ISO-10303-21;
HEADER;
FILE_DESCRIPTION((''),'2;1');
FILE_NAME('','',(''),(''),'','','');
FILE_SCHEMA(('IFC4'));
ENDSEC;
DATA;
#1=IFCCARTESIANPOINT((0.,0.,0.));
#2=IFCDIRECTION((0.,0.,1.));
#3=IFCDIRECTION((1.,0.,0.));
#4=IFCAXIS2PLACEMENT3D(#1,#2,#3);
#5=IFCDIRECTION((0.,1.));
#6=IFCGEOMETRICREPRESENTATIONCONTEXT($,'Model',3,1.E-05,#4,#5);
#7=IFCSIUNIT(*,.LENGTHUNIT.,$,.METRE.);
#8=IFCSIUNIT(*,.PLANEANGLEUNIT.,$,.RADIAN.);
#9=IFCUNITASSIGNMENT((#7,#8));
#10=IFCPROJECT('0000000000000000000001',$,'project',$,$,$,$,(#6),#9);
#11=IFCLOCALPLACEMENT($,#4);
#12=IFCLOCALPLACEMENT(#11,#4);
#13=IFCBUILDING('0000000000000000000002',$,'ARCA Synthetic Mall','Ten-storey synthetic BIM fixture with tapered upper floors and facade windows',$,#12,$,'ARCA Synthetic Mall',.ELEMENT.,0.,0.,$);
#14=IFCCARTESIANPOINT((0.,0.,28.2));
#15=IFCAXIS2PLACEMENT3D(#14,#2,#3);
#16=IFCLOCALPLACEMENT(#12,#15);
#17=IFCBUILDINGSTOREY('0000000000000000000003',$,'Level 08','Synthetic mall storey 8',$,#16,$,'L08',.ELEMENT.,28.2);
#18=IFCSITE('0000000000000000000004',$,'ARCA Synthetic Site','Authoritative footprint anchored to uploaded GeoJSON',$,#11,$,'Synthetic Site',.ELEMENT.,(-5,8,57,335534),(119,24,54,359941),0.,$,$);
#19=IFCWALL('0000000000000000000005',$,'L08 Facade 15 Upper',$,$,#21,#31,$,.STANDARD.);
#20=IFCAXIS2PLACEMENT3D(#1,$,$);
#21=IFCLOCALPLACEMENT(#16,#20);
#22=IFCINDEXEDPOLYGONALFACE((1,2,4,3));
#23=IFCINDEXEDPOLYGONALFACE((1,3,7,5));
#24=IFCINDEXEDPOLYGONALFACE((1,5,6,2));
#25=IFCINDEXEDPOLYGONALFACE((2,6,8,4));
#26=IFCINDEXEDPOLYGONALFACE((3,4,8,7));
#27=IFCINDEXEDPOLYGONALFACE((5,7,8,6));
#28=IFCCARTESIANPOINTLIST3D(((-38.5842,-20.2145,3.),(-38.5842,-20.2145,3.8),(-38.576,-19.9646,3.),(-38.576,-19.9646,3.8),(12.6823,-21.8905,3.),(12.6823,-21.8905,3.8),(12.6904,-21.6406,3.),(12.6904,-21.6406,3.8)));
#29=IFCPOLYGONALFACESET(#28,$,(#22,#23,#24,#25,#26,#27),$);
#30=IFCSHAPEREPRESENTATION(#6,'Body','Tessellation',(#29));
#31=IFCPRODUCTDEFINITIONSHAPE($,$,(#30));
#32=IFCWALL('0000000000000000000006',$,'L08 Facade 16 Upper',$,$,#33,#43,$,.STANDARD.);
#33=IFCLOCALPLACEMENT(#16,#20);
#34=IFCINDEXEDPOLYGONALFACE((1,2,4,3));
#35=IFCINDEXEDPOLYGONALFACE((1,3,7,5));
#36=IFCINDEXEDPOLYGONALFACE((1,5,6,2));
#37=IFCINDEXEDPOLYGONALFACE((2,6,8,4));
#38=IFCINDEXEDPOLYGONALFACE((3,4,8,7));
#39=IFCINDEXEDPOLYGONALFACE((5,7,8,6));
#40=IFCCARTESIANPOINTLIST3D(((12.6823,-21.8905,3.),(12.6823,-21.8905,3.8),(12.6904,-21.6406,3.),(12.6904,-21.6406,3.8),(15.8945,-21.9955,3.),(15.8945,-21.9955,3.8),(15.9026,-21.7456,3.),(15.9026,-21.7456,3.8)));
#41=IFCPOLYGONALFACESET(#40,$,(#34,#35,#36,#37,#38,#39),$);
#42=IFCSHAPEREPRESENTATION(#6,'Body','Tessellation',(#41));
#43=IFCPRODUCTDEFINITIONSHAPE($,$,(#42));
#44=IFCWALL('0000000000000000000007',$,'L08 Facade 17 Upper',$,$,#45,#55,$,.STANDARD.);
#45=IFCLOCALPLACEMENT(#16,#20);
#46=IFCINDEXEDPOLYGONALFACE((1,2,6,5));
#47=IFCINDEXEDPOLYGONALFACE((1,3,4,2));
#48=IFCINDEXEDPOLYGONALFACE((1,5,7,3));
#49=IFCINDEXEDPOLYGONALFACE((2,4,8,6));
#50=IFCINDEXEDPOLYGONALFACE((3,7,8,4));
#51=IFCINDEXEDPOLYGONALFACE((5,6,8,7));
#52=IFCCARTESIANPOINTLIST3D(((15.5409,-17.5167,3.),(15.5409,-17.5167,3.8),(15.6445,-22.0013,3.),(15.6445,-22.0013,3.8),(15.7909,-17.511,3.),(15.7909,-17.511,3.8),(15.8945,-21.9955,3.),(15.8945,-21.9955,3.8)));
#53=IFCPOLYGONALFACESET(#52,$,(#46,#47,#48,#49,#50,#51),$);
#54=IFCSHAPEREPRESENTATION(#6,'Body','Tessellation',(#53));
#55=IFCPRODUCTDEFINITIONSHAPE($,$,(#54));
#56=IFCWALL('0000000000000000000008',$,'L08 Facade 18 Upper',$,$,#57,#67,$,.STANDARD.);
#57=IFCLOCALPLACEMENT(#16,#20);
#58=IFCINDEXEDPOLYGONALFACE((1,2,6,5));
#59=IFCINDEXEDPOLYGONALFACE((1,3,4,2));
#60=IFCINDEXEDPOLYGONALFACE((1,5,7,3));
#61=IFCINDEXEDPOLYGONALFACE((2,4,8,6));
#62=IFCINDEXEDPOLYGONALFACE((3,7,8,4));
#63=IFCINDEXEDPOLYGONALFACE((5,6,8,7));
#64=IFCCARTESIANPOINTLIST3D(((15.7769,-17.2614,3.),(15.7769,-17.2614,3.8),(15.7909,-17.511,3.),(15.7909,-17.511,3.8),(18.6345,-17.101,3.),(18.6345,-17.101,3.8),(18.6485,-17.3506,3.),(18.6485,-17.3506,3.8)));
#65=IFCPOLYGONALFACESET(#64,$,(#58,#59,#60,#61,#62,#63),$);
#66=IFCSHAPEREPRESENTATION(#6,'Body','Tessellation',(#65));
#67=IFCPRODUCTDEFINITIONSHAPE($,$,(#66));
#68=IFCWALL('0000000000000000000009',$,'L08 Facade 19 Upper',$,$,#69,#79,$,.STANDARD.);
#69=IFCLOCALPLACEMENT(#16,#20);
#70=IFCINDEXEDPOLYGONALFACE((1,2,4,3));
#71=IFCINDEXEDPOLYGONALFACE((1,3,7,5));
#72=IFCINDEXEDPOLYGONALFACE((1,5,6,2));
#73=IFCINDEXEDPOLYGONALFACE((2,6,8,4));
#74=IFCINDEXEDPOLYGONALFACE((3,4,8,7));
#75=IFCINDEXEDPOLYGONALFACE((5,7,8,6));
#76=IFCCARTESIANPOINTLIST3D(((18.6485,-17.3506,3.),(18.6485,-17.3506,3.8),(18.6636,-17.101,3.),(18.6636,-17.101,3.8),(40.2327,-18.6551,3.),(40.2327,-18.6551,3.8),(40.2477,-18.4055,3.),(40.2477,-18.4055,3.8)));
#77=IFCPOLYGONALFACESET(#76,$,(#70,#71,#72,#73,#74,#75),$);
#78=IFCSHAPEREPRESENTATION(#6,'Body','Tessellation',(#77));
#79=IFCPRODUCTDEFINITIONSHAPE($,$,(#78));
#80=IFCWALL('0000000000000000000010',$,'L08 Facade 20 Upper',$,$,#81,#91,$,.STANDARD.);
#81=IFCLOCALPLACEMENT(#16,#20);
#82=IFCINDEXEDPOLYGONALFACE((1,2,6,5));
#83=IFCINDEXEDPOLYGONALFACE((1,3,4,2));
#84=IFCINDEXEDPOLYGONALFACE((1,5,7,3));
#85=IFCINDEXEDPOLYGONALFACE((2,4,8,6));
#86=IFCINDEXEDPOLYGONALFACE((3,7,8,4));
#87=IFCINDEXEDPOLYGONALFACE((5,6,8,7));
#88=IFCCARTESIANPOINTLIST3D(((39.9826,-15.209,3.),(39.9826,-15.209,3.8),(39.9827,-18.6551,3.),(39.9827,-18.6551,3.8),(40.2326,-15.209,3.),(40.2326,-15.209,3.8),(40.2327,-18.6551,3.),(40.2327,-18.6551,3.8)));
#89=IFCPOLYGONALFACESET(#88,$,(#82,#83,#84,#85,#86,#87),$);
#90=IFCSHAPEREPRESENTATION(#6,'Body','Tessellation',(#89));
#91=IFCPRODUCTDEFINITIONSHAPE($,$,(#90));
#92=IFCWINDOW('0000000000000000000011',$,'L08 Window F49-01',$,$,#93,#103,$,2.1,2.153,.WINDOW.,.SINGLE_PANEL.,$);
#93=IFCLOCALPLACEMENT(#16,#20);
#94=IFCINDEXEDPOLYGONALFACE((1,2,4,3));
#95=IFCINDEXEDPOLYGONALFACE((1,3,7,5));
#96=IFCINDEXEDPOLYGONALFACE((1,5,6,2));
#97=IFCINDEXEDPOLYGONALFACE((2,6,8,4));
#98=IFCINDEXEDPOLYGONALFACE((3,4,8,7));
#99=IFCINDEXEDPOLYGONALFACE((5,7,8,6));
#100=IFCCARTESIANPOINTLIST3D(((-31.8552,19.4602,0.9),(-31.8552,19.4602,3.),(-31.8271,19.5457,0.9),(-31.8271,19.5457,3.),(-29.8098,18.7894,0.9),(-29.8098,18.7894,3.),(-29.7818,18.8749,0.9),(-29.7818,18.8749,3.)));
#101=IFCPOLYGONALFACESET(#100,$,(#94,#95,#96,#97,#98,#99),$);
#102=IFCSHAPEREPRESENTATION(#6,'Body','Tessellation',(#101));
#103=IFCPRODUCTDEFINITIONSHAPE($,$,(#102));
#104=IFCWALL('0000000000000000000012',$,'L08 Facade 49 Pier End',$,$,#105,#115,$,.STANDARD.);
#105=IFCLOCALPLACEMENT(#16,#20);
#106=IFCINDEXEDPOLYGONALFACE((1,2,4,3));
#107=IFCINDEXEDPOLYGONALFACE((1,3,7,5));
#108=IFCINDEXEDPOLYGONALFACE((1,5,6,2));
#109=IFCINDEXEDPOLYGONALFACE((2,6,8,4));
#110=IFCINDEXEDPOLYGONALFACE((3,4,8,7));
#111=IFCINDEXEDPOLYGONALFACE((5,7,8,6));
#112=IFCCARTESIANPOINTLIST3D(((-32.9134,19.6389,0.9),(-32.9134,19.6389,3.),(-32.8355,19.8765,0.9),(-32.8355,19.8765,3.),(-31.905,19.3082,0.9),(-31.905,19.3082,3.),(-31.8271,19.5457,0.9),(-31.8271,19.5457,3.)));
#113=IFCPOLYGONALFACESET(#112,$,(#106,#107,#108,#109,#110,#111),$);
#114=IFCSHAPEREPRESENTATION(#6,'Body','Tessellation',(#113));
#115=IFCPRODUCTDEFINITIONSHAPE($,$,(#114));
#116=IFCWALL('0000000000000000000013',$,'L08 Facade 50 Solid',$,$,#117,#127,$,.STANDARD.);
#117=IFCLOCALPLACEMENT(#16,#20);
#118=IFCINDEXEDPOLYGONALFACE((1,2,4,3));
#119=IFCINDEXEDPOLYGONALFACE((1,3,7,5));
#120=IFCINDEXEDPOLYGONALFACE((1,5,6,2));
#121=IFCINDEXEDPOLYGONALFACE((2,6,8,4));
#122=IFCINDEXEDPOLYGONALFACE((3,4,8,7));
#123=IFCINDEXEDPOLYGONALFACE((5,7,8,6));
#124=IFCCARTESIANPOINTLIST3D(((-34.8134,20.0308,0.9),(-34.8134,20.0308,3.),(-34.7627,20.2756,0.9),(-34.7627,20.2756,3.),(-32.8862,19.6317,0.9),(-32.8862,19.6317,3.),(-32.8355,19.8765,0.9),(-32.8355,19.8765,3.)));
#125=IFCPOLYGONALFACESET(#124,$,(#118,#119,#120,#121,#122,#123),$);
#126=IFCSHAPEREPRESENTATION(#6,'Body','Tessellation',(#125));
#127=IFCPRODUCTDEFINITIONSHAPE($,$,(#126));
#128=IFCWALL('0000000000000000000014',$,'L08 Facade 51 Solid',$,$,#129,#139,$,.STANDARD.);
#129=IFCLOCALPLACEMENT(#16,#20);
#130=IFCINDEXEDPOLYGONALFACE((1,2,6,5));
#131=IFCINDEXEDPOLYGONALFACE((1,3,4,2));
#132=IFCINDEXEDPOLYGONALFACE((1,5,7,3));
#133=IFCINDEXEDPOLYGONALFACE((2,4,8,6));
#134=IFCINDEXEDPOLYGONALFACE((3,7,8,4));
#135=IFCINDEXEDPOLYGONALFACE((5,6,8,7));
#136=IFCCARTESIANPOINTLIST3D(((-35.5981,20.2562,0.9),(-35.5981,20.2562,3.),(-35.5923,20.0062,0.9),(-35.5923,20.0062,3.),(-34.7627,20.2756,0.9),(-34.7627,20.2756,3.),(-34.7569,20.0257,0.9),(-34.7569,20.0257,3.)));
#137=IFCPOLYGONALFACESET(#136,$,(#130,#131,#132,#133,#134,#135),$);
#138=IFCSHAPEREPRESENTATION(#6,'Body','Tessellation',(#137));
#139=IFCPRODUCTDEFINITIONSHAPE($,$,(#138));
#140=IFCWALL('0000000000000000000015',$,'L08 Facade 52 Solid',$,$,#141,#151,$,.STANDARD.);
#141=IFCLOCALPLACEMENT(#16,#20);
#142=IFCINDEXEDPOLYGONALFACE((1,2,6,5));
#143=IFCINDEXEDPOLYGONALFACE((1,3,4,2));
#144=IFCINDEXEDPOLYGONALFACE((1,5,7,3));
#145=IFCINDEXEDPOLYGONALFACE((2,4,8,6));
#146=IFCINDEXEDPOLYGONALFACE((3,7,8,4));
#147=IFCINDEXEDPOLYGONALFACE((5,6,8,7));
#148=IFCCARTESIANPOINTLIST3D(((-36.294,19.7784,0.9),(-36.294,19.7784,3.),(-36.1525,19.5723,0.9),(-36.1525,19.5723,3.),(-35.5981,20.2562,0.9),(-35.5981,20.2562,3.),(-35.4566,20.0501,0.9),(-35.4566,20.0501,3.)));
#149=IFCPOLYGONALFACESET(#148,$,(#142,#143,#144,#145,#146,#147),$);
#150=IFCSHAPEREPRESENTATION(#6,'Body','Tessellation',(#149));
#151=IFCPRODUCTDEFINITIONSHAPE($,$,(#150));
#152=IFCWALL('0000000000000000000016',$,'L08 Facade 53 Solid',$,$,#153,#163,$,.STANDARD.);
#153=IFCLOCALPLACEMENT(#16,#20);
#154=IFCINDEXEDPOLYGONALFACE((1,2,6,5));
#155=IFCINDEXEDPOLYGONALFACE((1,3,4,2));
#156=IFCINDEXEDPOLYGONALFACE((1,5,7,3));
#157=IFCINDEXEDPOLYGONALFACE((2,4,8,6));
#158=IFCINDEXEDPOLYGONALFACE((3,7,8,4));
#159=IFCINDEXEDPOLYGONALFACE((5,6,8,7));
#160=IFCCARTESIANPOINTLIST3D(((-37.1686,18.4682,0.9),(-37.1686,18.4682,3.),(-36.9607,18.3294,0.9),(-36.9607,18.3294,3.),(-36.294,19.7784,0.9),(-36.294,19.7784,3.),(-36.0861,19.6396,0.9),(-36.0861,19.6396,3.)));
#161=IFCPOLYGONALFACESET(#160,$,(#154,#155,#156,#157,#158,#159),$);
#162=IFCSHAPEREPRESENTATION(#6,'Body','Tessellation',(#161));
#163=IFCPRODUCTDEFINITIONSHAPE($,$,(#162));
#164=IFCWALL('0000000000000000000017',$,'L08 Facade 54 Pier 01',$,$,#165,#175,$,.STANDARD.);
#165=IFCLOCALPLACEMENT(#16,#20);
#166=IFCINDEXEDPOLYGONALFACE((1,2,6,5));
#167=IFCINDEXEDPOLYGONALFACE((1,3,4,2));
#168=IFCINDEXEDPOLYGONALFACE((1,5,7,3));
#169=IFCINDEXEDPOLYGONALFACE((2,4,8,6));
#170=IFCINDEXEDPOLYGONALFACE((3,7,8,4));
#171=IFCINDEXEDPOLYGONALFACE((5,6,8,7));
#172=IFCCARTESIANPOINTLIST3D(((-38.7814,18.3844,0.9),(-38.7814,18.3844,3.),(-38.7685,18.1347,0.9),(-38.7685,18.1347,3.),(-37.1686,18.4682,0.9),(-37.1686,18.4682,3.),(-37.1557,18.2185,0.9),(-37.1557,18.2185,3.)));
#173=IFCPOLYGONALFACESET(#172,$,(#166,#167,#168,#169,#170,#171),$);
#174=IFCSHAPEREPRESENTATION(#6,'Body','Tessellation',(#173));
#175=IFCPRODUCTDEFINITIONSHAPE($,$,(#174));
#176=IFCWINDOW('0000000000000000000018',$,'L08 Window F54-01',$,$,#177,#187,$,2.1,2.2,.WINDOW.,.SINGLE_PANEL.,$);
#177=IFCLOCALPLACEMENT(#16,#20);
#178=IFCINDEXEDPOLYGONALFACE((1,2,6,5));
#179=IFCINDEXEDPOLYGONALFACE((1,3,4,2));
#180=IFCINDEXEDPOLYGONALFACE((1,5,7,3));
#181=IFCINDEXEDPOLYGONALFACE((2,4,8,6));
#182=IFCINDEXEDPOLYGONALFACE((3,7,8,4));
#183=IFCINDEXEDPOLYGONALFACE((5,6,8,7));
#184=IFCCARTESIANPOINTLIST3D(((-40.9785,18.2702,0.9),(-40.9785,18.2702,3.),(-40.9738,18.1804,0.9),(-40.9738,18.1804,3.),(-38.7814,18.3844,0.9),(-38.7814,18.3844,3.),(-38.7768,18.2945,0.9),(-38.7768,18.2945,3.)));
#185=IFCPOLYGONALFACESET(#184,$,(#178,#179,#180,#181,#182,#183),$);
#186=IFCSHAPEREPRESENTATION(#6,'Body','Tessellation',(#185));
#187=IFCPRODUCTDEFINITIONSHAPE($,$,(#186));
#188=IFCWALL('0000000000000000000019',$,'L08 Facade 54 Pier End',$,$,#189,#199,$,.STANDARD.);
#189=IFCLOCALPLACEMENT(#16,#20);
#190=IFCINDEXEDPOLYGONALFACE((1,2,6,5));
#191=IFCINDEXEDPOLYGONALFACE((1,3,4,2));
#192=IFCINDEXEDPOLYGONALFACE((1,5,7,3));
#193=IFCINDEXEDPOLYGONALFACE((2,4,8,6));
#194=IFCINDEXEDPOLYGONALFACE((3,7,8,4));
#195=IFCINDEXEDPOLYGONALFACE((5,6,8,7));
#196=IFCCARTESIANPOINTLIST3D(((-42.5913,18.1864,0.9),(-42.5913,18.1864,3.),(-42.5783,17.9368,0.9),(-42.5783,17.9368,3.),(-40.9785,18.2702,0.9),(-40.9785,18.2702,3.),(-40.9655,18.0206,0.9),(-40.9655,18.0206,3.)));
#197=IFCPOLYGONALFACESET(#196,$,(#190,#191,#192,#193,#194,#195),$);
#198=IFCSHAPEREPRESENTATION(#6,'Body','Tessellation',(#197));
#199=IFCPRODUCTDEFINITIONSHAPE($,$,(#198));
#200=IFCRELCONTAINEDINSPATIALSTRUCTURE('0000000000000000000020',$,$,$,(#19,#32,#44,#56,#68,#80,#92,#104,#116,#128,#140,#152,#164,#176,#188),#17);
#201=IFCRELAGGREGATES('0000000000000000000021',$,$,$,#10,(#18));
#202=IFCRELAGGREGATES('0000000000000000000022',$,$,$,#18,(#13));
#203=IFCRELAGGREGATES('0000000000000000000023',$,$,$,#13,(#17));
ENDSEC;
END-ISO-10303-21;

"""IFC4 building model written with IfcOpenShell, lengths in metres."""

from ifc_helpers import new_model, si_unit, direction, frame, origin_with_axes, place, context, project, spatial, polyline, outline, extrude, element, save


model = new_model("IFC4")

# Units and contexts
model_context = context("Model", 3, precision=1e-05, world=origin_with_axes(), true_north=direction((0.0, 1.0)))
ifc_project = project(units=[si_unit("LENGTHUNIT", "METRE"), si_unit("PLANEANGLEUNIT", "RADIAN")], contexts=[model_context])

# Site, building, storey
site_placement = place(None, origin_with_axes())
site = spatial("IfcSite", under=ifc_project, at=site_placement, Name="ARCA Synthetic Site", Description="Authoritative footprint anchored to uploaded GeoJSON", LongName="Synthetic Site", CompositionType="ELEMENT", RefLatitude=(-5, 8, 57, 335534), RefLongitude=(119, 24, 54, 359941), RefElevation=0.0)
building_placement = place(site_placement, origin_with_axes())
building = spatial("IfcBuilding", under=site, at=building_placement, Name="ARCA Synthetic Mall", Description="Ten-storey synthetic BIM fixture with tapered upper floors and facade windows", LongName="ARCA Synthetic Mall", CompositionType="ELEMENT", ElevationOfRefHeight=0.0, ElevationOfTerrain=0.0)
storey_placement = place(building_placement, frame((0.0, 0.0, 28.2), z_axis=(0.0, 0.0, 1.0), x_axis=(1.0, 0.0, 0.0)))
storey = spatial("IfcBuildingStorey", under=building, at=storey_placement, Name="Level 08", Description="Synthetic mall storey 8", LongName="L08", CompositionType="ELEMENT", Elevation=28.2)

# Walls
wall_1_placement = place(storey_placement, frame((0.0, 0.0, 3.0), z_axis=(0.0, 0.0, 1.0), x_axis=(1.0, 0.0, 0.0)))
element("IfcWall", 1, at=wall_1_placement, inside=storey, Name="L08 Facade 15 Upper", PredefinedType="STANDARD", context=model_context, shape_type="SweptSolid", body=[
    extrude(outline(polyline([(-38.5842, -20.2145), (12.6823, -21.8905), (12.6904, -21.6406), (-38.576, -19.9646), (-38.5842, -20.2145)])), origin_with_axes(), (0.0, 0.0, 1.0), 0.8),
])
wall_2_placement = place(storey_placement, frame((0.0, 0.0, 3.0), z_axis=(0.0, 0.0, 1.0), x_axis=(1.0, 0.0, 0.0)))
element("IfcWall", 2, at=wall_2_placement, inside=storey, Name="L08 Facade 16 Upper", PredefinedType="STANDARD", context=model_context, shape_type="SweptSolid", body=[
    extrude(outline(polyline([(12.6823, -21.8905), (15.8945, -21.9955), (15.9026, -21.7456), (12.6904, -21.6406), (12.6823, -21.8905)])), origin_with_axes(), (0.0, 0.0, 1.0), 0.8),
])
wall_3_placement = place(storey_placement, frame((0.0, 0.0, 3.0), z_axis=(0.0, 0.0, 1.0), x_axis=(1.0, 0.0, 0.0)))
element("IfcWall", 3, at=wall_3_placement, inside=storey, Name="L08 Facade 17 Upper", PredefinedType="STANDARD", context=model_context, shape_type="SweptSolid", body=[
    extrude(outline(polyline([(15.8945, -21.9955), (15.7909, -17.511), (15.5409, -17.5167), (15.6445, -22.0013), (15.8945, -21.9955)])), origin_with_axes(), (0.0, 0.0, 1.0), 0.8),
])
wall_4_placement = place(storey_placement, frame((0.0, 0.0, 3.0), z_axis=(0.0, 0.0, 1.0), x_axis=(1.0, 0.0, 0.0)))
element("IfcWall", 4, at=wall_4_placement, inside=storey, Name="L08 Facade 18 Upper", PredefinedType="STANDARD", context=model_context, shape_type="SweptSolid", body=[
    extrude(outline(polyline([(15.7909, -17.511), (18.6485, -17.3506), (18.6345, -17.101), (15.7769, -17.2614), (15.7909, -17.511)])), origin_with_axes(), (0.0, 0.0, 1.0), 0.8),
])
wall_5_placement = place(storey_placement, frame((0.0, 0.0, 3.0), z_axis=(0.0, 0.0, 1.0), x_axis=(1.0, 0.0, 0.0)))
element("IfcWall", 5, at=wall_5_placement, inside=storey, Name="L08 Facade 19 Upper", PredefinedType="STANDARD", context=model_context, shape_type="SweptSolid", body=[
    extrude(outline(polyline([(18.6485, -17.3506), (40.2327, -18.6551), (40.2477, -18.4055), (18.6636, -17.101), (18.6485, -17.3506)])), origin_with_axes(), (0.0, 0.0, 1.0), 0.8),
])
wall_6_placement = place(storey_placement, frame((0.0, 0.0, 3.0), z_axis=(0.0, 0.0, 1.0), x_axis=(1.0, 0.0, 0.0)))
element("IfcWall", 6, at=wall_6_placement, inside=storey, Name="L08 Facade 20 Upper", PredefinedType="STANDARD", context=model_context, shape_type="SweptSolid", body=[
    extrude(outline(polyline([(40.2327, -18.6551), (40.2326, -15.209), (39.9826, -15.209), (39.9827, -18.6551), (40.2327, -18.6551)])), origin_with_axes(), (0.0, 0.0, 1.0), 0.8),
])

# Window
window_1_placement = place(storey_placement, frame((0.0, 0.0, 0.9), z_axis=(0.0, 0.0, 1.0), x_axis=(1.0, 0.0, 0.0)))
element("IfcWindow", 7, at=window_1_placement, inside=storey, Name="L08 Window F49-01", OverallHeight=2.1, OverallWidth=2.153, PartitioningType="SINGLE_PANEL", PredefinedType="WINDOW", context=model_context, shape_type="SweptSolid", body=[
    extrude(outline(polyline([(-29.7818, 18.8749), (-31.8271, 19.5457), (-31.8552, 19.4602), (-29.8098, 18.7894), (-29.7818, 18.8749)])), origin_with_axes(), (0.0, 0.0, 1.0), 2.1),
])

# Walls
wall_7_placement = place(storey_placement, frame((0.0, 0.0, 0.9), z_axis=(0.0, 0.0, 1.0), x_axis=(1.0, 0.0, 0.0)))
element("IfcWall", 8, at=wall_7_placement, inside=storey, Name="L08 Facade 49 Pier End", PredefinedType="STANDARD", context=model_context, shape_type="SweptSolid", body=[
    extrude(outline(polyline([(-31.8271, 19.5457), (-32.8355, 19.8765), (-32.9134, 19.6389), (-31.905, 19.3082), (-31.8271, 19.5457)])), origin_with_axes(), (0.0, 0.0, 1.0), 2.1),
])
wall_8_placement = place(storey_placement, frame((0.0, 0.0, 0.9), z_axis=(0.0, 0.0, 1.0), x_axis=(1.0, 0.0, 0.0)))
element("IfcWall", 9, at=wall_8_placement, inside=storey, Name="L08 Facade 50 Solid", PredefinedType="STANDARD", context=model_context, shape_type="SweptSolid", body=[
    extrude(outline(polyline([(-32.8355, 19.8765), (-34.7627, 20.2756), (-34.8134, 20.0308), (-32.8862, 19.6317), (-32.8355, 19.8765)])), origin_with_axes(), (0.0, 0.0, 1.0), 2.1),
])
wall_9_placement = place(storey_placement, frame((0.0, 0.0, 0.9), z_axis=(0.0, 0.0, 1.0), x_axis=(1.0, 0.0, 0.0)))
element("IfcWall", 10, at=wall_9_placement, inside=storey, Name="L08 Facade 51 Solid", PredefinedType="STANDARD", context=model_context, shape_type="SweptSolid", body=[
    extrude(outline(polyline([(-34.7627, 20.2756), (-35.5981, 20.2562), (-35.5923, 20.0062), (-34.7569, 20.0257), (-34.7627, 20.2756)])), origin_with_axes(), (0.0, 0.0, 1.0), 2.1),
])
wall_10_placement = place(storey_placement, frame((0.0, 0.0, 0.9), z_axis=(0.0, 0.0, 1.0), x_axis=(1.0, 0.0, 0.0)))
element("IfcWall", 11, at=wall_10_placement, inside=storey, Name="L08 Facade 52 Solid", PredefinedType="STANDARD", context=model_context, shape_type="SweptSolid", body=[
    extrude(outline(polyline([(-35.5981, 20.2562), (-36.294, 19.7784), (-36.1525, 19.5723), (-35.4566, 20.0501), (-35.5981, 20.2562)])), origin_with_axes(), (0.0, 0.0, 1.0), 2.1),
])
wall_11_placement = place(storey_placement, frame((0.0, 0.0, 0.9), z_axis=(0.0, 0.0, 1.0), x_axis=(1.0, 0.0, 0.0)))
element("IfcWall", 12, at=wall_11_placement, inside=storey, Name="L08 Facade 53 Solid", PredefinedType="STANDARD", context=model_context, shape_type="SweptSolid", body=[
    extrude(outline(polyline([(-36.294, 19.7784), (-37.1686, 18.4682), (-36.9607, 18.3294), (-36.0861, 19.6396), (-36.294, 19.7784)])), origin_with_axes(), (0.0, 0.0, 1.0), 2.1),
])
wall_12_placement = place(storey_placement, frame((0.0, 0.0, 0.9), z_axis=(0.0, 0.0, 1.0), x_axis=(1.0, 0.0, 0.0)))
element("IfcWall", 13, at=wall_12_placement, inside=storey, Name="L08 Facade 54 Pier 01", PredefinedType="STANDARD", context=model_context, shape_type="SweptSolid", body=[
    extrude(outline(polyline([(-37.1686, 18.4682), (-38.7814, 18.3844), (-38.7685, 18.1347), (-37.1557, 18.2185), (-37.1686, 18.4682)])), origin_with_axes(), (0.0, 0.0, 1.0), 2.1),
])

# Window
window_2_placement = place(storey_placement, frame((0.0, 0.0, 0.9), z_axis=(0.0, 0.0, 1.0), x_axis=(1.0, 0.0, 0.0)))
element("IfcWindow", 14, at=window_2_placement, inside=storey, Name="L08 Window F54-01", OverallHeight=2.1, OverallWidth=2.2, PartitioningType="SINGLE_PANEL", PredefinedType="WINDOW", context=model_context, shape_type="SweptSolid", body=[
    extrude(outline(polyline([(-38.7814, 18.3844), (-40.9785, 18.2702), (-40.9738, 18.1804), (-38.7768, 18.2945), (-38.7814, 18.3844)])), origin_with_axes(), (0.0, 0.0, 1.0), 2.1),
])

# Wall
wall_13_placement = place(storey_placement, frame((0.0, 0.0, 0.9), z_axis=(0.0, 0.0, 1.0), x_axis=(1.0, 0.0, 0.0)))
element("IfcWall", 15, at=wall_13_placement, inside=storey, Name="L08 Facade 54 Pier End", PredefinedType="STANDARD", context=model_context, shape_type="SweptSolid", body=[
    extrude(outline(polyline([(-40.9785, 18.2702), (-42.5913, 18.1864), (-42.5783, 17.9368), (-40.9655, 18.0206), (-40.9785, 18.2702)])), origin_with_axes(), (0.0, 0.0, 1.0), 2.1),
])

save(model, "model.ifc")
